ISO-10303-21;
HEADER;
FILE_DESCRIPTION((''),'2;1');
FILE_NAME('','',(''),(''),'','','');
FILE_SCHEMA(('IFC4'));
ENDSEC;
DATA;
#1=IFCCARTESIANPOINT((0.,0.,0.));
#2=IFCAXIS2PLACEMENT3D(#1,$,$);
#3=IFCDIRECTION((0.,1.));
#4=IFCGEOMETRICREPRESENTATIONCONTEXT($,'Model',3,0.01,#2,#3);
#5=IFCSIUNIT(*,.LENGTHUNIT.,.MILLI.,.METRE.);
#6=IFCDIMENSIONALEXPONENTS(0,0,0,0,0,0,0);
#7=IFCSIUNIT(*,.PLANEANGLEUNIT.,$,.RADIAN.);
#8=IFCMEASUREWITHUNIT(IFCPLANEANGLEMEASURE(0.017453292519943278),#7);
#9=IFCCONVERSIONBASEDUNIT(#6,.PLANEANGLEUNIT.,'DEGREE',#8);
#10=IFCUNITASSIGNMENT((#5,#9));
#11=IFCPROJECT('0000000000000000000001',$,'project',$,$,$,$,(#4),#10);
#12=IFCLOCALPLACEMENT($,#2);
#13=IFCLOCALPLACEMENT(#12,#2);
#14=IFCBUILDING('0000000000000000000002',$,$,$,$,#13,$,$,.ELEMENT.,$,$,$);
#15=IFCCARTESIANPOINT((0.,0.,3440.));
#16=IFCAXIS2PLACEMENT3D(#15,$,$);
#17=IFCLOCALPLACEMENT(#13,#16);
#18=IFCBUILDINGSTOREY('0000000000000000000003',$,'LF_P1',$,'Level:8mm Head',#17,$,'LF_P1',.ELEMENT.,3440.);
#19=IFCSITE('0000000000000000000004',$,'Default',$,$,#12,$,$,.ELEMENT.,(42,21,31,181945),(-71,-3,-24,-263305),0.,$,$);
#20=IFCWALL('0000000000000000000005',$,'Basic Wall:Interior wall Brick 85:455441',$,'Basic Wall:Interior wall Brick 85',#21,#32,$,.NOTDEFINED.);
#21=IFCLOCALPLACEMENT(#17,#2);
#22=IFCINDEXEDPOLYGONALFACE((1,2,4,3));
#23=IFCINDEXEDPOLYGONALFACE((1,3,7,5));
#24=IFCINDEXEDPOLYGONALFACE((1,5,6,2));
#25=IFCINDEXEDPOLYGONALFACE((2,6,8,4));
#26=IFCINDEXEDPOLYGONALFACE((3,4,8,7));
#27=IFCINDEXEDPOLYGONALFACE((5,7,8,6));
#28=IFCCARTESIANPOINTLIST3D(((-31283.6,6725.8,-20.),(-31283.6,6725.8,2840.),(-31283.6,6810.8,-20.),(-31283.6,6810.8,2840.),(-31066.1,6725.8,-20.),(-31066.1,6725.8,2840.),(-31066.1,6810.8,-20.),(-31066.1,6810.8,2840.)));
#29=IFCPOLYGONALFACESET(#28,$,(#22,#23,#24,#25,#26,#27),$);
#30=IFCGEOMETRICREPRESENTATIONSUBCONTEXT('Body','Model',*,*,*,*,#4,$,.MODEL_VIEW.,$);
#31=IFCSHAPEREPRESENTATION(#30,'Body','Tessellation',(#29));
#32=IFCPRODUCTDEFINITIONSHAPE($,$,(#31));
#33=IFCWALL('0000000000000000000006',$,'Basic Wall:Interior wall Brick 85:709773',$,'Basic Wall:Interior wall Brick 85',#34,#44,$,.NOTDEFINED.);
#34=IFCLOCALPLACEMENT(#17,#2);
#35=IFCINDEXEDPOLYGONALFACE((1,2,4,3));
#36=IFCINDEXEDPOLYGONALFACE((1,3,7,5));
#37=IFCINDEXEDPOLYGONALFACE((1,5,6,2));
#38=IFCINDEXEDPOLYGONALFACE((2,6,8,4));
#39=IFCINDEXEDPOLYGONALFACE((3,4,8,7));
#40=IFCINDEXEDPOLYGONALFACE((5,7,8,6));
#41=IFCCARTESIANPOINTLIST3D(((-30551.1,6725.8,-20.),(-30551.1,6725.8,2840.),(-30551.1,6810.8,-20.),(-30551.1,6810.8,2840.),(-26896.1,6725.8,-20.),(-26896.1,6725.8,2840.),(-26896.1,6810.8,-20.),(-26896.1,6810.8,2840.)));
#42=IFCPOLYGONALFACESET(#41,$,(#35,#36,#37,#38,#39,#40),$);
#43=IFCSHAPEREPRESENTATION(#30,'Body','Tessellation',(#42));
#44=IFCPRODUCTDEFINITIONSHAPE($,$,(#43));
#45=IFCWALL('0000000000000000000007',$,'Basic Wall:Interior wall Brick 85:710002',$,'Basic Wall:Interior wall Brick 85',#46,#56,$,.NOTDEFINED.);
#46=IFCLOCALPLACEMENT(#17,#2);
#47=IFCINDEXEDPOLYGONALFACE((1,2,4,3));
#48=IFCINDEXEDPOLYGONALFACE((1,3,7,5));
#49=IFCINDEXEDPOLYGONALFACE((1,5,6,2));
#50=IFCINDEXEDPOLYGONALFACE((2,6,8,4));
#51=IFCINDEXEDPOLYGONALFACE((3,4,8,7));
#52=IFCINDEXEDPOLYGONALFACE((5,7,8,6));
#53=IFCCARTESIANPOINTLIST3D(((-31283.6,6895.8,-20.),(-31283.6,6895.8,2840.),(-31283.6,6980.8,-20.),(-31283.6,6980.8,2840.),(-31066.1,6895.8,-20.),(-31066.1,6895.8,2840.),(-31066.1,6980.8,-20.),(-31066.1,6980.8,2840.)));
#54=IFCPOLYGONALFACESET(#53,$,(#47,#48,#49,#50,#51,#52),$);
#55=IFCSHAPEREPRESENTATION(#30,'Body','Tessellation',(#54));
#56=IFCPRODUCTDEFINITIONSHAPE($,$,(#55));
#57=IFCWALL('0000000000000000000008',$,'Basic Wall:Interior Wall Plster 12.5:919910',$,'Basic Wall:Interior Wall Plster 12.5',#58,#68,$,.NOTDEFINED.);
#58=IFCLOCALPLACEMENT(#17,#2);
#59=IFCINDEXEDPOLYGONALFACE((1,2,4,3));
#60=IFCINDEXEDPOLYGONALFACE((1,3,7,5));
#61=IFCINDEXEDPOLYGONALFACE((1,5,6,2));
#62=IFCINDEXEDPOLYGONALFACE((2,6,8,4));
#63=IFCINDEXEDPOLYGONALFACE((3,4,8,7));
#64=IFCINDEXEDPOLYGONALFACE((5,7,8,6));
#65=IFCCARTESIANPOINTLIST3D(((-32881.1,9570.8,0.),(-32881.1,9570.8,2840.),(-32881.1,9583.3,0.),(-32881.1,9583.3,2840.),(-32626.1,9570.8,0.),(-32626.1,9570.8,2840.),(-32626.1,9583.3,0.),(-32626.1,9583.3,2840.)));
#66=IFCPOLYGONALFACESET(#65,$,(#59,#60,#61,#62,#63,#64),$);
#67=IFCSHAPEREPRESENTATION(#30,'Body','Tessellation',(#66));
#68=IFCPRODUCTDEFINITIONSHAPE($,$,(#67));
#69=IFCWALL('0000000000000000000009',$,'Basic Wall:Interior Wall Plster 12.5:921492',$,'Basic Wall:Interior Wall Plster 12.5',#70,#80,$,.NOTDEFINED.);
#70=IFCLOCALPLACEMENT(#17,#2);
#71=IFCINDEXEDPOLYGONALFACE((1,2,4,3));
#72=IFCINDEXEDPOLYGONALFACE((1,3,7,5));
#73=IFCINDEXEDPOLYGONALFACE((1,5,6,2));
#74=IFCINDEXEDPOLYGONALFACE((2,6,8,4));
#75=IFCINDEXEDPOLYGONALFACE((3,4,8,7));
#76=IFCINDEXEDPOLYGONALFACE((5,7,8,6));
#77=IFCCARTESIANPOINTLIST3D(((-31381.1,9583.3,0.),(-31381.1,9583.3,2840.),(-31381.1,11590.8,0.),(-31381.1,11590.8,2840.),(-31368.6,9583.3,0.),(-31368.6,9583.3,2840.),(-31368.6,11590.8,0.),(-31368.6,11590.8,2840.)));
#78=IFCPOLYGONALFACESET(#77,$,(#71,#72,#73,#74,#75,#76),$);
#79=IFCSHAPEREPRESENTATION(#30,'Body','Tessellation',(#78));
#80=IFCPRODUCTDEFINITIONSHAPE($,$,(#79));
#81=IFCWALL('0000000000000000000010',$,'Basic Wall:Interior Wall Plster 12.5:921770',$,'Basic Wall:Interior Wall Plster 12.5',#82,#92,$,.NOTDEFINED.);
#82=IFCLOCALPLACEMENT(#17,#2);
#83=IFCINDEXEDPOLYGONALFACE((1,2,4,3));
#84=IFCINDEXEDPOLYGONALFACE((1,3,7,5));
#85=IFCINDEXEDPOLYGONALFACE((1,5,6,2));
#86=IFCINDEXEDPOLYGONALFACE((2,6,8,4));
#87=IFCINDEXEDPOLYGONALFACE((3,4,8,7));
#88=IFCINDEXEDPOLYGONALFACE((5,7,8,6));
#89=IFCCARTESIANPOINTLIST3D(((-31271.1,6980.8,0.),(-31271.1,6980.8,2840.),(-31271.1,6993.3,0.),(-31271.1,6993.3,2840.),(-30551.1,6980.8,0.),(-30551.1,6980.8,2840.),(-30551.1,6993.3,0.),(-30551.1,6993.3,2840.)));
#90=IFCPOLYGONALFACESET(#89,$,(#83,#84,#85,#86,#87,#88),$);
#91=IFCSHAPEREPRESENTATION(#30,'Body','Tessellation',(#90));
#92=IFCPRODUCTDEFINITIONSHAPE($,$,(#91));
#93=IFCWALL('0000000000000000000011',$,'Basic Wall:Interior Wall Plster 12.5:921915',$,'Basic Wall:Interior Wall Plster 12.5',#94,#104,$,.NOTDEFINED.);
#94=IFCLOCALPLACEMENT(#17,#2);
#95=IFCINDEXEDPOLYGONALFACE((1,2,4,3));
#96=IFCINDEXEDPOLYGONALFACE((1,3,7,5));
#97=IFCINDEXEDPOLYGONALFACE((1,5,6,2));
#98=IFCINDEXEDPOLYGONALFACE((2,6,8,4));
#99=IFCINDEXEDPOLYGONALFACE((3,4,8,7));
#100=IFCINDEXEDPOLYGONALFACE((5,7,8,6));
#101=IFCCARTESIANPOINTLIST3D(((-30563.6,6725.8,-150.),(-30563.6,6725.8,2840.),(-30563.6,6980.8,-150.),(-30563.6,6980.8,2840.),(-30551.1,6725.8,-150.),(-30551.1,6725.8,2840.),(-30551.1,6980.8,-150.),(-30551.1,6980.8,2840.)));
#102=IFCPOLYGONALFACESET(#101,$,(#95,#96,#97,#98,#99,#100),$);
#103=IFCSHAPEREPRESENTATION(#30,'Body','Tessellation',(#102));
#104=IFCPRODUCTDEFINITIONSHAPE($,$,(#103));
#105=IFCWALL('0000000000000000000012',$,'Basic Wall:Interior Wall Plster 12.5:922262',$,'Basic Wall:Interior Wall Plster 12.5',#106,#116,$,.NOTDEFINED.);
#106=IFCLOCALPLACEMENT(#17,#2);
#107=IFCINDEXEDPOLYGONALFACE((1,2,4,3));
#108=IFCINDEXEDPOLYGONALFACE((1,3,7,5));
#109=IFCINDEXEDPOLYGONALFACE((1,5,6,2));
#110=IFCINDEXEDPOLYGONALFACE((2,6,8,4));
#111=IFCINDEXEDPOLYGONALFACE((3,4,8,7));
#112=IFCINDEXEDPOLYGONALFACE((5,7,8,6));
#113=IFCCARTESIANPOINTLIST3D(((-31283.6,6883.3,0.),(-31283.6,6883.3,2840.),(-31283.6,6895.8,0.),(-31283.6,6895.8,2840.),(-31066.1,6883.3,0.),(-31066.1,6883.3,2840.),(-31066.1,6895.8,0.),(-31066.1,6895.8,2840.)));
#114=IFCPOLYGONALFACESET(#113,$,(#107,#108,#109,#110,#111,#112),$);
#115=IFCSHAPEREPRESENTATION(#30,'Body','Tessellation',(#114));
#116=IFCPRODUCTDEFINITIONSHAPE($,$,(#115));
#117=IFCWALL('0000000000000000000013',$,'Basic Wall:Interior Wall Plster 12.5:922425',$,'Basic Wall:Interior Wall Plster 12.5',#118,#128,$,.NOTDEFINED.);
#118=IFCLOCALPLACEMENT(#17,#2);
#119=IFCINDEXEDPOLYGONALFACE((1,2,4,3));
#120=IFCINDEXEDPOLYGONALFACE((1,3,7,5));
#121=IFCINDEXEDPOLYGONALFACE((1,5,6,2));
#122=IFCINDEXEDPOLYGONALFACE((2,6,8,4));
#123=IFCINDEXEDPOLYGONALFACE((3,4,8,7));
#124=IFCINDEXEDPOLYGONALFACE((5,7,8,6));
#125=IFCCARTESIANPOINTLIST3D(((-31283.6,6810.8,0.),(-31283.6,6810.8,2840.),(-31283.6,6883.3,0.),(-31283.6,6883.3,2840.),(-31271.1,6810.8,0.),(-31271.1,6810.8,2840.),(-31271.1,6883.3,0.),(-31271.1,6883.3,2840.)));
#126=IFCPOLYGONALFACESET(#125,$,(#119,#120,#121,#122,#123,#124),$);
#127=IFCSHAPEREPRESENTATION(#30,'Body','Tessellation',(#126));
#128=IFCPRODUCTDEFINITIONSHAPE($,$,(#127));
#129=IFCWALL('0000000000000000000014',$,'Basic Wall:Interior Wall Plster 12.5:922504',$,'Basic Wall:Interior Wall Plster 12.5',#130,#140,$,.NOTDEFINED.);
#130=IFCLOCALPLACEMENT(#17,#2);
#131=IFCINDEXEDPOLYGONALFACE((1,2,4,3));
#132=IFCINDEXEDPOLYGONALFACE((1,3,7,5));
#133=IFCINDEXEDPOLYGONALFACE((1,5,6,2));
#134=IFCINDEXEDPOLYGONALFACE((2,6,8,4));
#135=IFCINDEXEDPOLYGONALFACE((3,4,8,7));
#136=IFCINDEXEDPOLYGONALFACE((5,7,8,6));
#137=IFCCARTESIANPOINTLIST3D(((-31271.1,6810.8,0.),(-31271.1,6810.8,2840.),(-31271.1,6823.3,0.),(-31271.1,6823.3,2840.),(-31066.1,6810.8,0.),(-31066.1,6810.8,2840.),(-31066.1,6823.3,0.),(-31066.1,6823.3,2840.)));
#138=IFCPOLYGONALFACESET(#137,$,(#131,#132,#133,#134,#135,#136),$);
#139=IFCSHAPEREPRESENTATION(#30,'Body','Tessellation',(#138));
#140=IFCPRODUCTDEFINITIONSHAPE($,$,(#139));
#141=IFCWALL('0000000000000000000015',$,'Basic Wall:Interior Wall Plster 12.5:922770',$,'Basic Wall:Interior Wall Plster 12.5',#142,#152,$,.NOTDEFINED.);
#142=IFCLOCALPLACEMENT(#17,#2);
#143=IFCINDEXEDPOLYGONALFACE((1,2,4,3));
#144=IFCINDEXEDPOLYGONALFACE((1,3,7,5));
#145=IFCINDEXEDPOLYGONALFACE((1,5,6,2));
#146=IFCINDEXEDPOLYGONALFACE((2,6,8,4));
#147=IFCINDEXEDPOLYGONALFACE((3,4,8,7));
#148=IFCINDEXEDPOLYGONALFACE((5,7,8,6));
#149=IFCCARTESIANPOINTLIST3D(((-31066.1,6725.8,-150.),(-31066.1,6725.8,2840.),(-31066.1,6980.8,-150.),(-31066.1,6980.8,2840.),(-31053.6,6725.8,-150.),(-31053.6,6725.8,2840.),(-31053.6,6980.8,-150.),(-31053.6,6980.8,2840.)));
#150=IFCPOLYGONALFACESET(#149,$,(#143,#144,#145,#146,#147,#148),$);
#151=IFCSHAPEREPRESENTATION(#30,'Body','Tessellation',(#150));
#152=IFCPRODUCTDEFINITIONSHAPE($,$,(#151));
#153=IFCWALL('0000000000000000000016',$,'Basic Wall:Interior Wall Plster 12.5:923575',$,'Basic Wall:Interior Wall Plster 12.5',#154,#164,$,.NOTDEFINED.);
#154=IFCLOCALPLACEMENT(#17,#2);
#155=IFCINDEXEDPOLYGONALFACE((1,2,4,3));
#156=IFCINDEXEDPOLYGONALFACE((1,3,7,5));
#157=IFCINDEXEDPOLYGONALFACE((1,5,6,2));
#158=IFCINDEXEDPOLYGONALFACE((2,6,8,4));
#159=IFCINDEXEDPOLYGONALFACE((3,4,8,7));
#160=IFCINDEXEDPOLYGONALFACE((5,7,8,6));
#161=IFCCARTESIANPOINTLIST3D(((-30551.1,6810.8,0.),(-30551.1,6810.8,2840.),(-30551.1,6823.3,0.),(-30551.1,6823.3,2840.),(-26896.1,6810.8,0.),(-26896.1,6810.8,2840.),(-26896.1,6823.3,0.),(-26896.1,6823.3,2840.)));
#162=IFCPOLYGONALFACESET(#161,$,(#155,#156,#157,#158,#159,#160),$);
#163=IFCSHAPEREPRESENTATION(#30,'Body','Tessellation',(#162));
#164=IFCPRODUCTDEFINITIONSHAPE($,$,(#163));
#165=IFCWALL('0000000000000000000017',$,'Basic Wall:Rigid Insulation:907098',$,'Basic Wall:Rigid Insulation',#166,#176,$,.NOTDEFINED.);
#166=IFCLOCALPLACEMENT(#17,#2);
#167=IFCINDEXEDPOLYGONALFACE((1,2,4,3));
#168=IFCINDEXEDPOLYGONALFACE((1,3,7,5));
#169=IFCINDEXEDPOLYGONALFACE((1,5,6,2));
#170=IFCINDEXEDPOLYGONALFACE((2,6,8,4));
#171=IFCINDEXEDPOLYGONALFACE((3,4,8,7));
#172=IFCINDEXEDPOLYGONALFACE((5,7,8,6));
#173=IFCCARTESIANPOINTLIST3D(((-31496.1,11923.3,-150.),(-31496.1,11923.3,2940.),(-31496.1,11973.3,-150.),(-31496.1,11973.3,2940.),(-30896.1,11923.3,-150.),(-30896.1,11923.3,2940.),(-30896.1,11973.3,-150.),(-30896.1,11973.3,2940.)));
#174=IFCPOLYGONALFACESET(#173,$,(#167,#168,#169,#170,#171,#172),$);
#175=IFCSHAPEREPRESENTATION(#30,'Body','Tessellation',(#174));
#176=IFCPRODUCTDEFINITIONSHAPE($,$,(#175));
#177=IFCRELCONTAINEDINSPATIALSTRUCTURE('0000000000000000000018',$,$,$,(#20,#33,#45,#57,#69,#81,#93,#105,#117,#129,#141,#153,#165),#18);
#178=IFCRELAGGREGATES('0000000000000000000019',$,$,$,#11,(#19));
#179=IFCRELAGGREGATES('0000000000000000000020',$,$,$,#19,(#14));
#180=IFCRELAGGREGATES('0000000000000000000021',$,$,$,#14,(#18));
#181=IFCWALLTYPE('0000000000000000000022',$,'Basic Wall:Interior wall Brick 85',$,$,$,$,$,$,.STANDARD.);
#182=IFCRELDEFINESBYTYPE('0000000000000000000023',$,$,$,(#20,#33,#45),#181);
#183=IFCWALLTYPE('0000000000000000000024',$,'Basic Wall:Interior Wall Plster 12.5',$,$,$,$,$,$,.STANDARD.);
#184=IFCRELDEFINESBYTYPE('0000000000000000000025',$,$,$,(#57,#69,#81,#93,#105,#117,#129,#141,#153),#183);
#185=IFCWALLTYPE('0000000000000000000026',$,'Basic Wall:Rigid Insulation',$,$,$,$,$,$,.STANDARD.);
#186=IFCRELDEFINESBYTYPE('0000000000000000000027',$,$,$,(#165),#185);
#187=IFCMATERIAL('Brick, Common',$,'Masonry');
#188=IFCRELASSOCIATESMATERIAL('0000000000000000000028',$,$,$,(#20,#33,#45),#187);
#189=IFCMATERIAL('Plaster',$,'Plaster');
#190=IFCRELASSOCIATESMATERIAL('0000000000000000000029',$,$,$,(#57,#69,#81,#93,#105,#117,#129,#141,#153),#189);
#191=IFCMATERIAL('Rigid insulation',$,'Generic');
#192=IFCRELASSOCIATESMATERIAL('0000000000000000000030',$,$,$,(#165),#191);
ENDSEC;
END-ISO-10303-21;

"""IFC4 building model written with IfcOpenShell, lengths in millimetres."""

from ifc_helpers import new_model, entity, si_unit, converted_unit, direction, frame, origin, place, context, subcontext, project, spatial, indexed_curve, outline, extrude, material, type_object, element, save


model = new_model("IFC4")

# Units and contexts
model_context = context("Model", 3, precision=0.01, world=origin(), true_north=direction((0.0, 1.0)))
body_context = subcontext(model_context, "Body", "Model", "MODEL_VIEW")
ifc_project = project(units=[si_unit("LENGTHUNIT", "METRE", prefix="MILLI"), converted_unit("PLANEANGLEUNIT", "DEGREE", entity("IfcPlaneAngleMeasure", 0.017453292519943278), si_unit("PLANEANGLEUNIT", "RADIAN"), dimensions=[0, 0, 0, 0, 0, 0, 0])], contexts=[model_context])

# Site, building, storey
site_placement = place(None, origin())
site = spatial("IfcSite", under=ifc_project, at=site_placement, Name="Default", CompositionType="ELEMENT", RefLatitude=(42, 21, 31, 181945), RefLongitude=(-71, -3, -24, -263305), RefElevation=0.0)
building_placement = place(site_placement, origin())
building = spatial("IfcBuilding", under=site, at=building_placement, CompositionType="ELEMENT")
storey_placement = place(building_placement, frame((0.0, 0.0, 3440.0)))
storey = spatial("IfcBuildingStorey", under=building, at=storey_placement, Name="LF_P1", ObjectType="Level:8mm Head", LongName="LF_P1", CompositionType="ELEMENT", Elevation=3440.0)

# Walls
ifc_material_1 = material(Name="Brick, Common", Category="Masonry")
wall_type_1 = type_object("IfcWallType", Name="Basic Wall:Interior wall Brick 85", PredefinedType="STANDARD")
wall_1_placement = place(storey_placement, frame((-31283.6, 6768.3, -20.0)))
element("IfcWall", 1, at=wall_1_placement, inside=storey, type_object=wall_type_1, material=ifc_material_1, Name="Basic Wall:Interior wall Brick 85:455441", ObjectType="Basic Wall:Interior wall Brick 85", PredefinedType="NOTDEFINED", context=body_context, shape_type="SweptSolid", body=[
    extrude(outline(indexed_curve([(217.5, 42.5), (0.0, 42.5), (0.0, -42.5), (217.5, -42.5), (217.5, 42.5)], self_intersect=False)), origin(), (0.0, 0.0, 1.0), 2860.0),
])
wall_2_placement = place(storey_placement, frame((-30551.1, 6768.3, -20.0)))
element("IfcWall", 2, at=wall_2_placement, inside=storey, type_object=wall_type_1, material=ifc_material_1, Name="Basic Wall:Interior wall Brick 85:709773", ObjectType="Basic Wall:Interior wall Brick 85", PredefinedType="NOTDEFINED", context=body_context, shape_type="SweptSolid", body=[
    extrude(outline(indexed_curve([(3655.0, 42.5), (0.0, 42.5), (0.0, -42.5), (3655.0, -42.5), (3655.0, 42.5)], self_intersect=False)), origin(), (0.0, 0.0, 1.0), 2860.0),
])
wall_3_placement = place(storey_placement, frame((-31283.6, 6938.3, -20.0)))
element("IfcWall", 3, at=wall_3_placement, inside=storey, type_object=wall_type_1, material=ifc_material_1, Name="Basic Wall:Interior wall Brick 85:710002", ObjectType="Basic Wall:Interior wall Brick 85", PredefinedType="NOTDEFINED", context=body_context, shape_type="SweptSolid", body=[
    extrude(outline(indexed_curve([(217.5, 42.5), (0.0, 42.5), (0.0, -42.5), (217.5, -42.5), (217.5, 42.5)], self_intersect=False)), origin(), (0.0, 0.0, 1.0), 2860.0),
])
ifc_material_2 = material(Name="Plaster", Category="Plaster")
wall_type_2 = type_object("IfcWallType", Name="Basic Wall:Interior Wall Plster 12.5", PredefinedType="STANDARD")
wall_4_placement = place(storey_placement, frame((-32881.1, 9577.1, 0.0)))
element("IfcWall", 4, at=wall_4_placement, inside=storey, type_object=wall_type_2, material=ifc_material_2, Name="Basic Wall:Interior Wall Plster 12.5:919910", ObjectType="Basic Wall:Interior Wall Plster 12.5", PredefinedType="NOTDEFINED", context=body_context, shape_type="SweptSolid", body=[
    extrude(outline(indexed_curve([(255.0, 6.2), (0.0, 6.2), (0.0, -6.2), (255.0, -6.2), (255.0, 6.2)], self_intersect=False)), origin(), (0.0, 0.0, 1.0), 2840.0),
])
wall_5_placement = place(storey_placement, frame((-31374.9, 9583.3, 0.0), z_axis=(0.0, 0.0, 1.0), x_axis=(0.0, 1.0, 0.0)))
element("IfcWall", 5, at=wall_5_placement, inside=storey, type_object=wall_type_2, material=ifc_material_2, Name="Basic Wall:Interior Wall Plster 12.5:921492", ObjectType="Basic Wall:Interior Wall Plster 12.5", PredefinedType="NOTDEFINED", context=body_context, shape_type="SweptSolid", body=[
    extrude(outline(indexed_curve([(2007.5, 6.2), (0.0, 6.2), (0.0, -6.2), (2007.5, -6.2), (2007.5, 6.2)], self_intersect=False)), origin(), (0.0, 0.0, 1.0), 2840.0),
])
wall_6_placement = place(storey_placement, frame((-31271.1, 6987.1, 0.0)))
element("IfcWall", 6, at=wall_6_placement, inside=storey, type_object=wall_type_2, material=ifc_material_2, Name="Basic Wall:Interior Wall Plster 12.5:921770", ObjectType="Basic Wall:Interior Wall Plster 12.5", PredefinedType="NOTDEFINED", context=body_context, shape_type="SweptSolid", body=[
    extrude(outline(indexed_curve([(720.0, 6.2), (0.0, 6.2), (0.0, -6.2), (720.0, -6.2), (720.0, 6.2)], self_intersect=False)), origin(), (0.0, 0.0, 1.0), 2840.0),
])
wall_7_placement = place(storey_placement, frame((-30557.4, 6980.8, -150.0), z_axis=(0.0, 0.0, 1.0), x_axis=(0.0, -1.0, 0.0)))
element("IfcWall", 7, at=wall_7_placement, inside=storey, type_object=wall_type_2, material=ifc_material_2, Name="Basic Wall:Interior Wall Plster 12.5:921915", ObjectType="Basic Wall:Interior Wall Plster 12.5", PredefinedType="NOTDEFINED", context=body_context, shape_type="SweptSolid", body=[
    extrude(outline(indexed_curve([(255.0, 6.2), (0.0, 6.2), (0.0, -6.2), (255.0, -6.2), (255.0, 6.2)], self_intersect=False)), origin(), (0.0, 0.0, 1.0), 2990.0),
])
wall_8_placement = place(storey_placement, frame((-31283.6, 6889.6, 0.0)))
element("IfcWall", 8, at=wall_8_placement, inside=storey, type_object=wall_type_2, material=ifc_material_2, Name="Basic Wall:Interior Wall Plster 12.5:922262", ObjectType="Basic Wall:Interior Wall Plster 12.5", PredefinedType="NOTDEFINED", context=body_context, shape_type="SweptSolid", body=[
    extrude(outline(indexed_curve([(217.5, 6.2), (0.0, 6.2), (0.0, -6.2), (217.5, -6.2), (217.5, 6.2)], self_intersect=False)), origin(), (0.0, 0.0, 1.0), 2840.0),
])
wall_9_placement = place(storey_placement, frame((-31277.4, 6883.3, 0.0), z_axis=(0.0, 0.0, 1.0), x_axis=(0.0, -1.0, 0.0)))
element("IfcWall", 9, at=wall_9_placement, inside=storey, type_object=wall_type_2, material=ifc_material_2, Name="Basic Wall:Interior Wall Plster 12.5:922425", ObjectType="Basic Wall:Interior Wall Plster 12.5", PredefinedType="NOTDEFINED", context=body_context, shape_type="SweptSolid", body=[
    extrude(outline(indexed_curve([(72.5, 6.2), (0.0, 6.2), (0.0, -6.2), (72.5, -6.2), (72.5, 6.2)], self_intersect=False)), origin(), (0.0, 0.0, 1.0), 2840.0),
])
wall_10_placement = place(storey_placement, frame((-31271.1, 6817.1, 0.0)))
element("IfcWall", 10, at=wall_10_placement, inside=storey, type_object=wall_type_2, material=ifc_material_2, Name="Basic Wall:Interior Wall Plster 12.5:922504", ObjectType="Basic Wall:Interior Wall Plster 12.5", PredefinedType="NOTDEFINED", context=body_context, shape_type="SweptSolid", body=[
    extrude(outline(indexed_curve([(205.0, 6.2), (0.0, 6.2), (0.0, -6.2), (205.0, -6.2), (205.0, 6.2)], self_intersect=False)), origin(), (0.0, 0.0, 1.0), 2840.0),
])
wall_11_placement = place(storey_placement, frame((-31059.9, 6725.8, -150.0), z_axis=(0.0, 0.0, 1.0), x_axis=(0.0, 1.0, 0.0)))
element("IfcWall", 11, at=wall_11_placement, inside=storey, type_object=wall_type_2, material=ifc_material_2, Name="Basic Wall:Interior Wall Plster 12.5:922770", ObjectType="Basic Wall:Interior Wall Plster 12.5", PredefinedType="NOTDEFINED", context=body_context, shape_type="SweptSolid", body=[
    extrude(outline(indexed_curve([(255.0, 6.2), (0.0, 6.2), (0.0, -6.2), (255.0, -6.2), (255.0, 6.2)], self_intersect=False)), origin(), (0.0, 0.0, 1.0), 2990.0),
])
wall_12_placement = place(storey_placement, frame((-30551.1, 6817.1, 0.0)))
element("IfcWall", 12, at=wall_12_placement, inside=storey, type_object=wall_type_2, material=ifc_material_2, Name="Basic Wall:Interior Wall Plster 12.5:923575", ObjectType="Basic Wall:Interior Wall Plster 12.5", PredefinedType="NOTDEFINED", context=body_context, shape_type="SweptSolid", body=[
    extrude(outline(indexed_curve([(3655.0, 6.2), (0.0, 6.2), (0.0, -6.2), (3655.0, -6.2), (3655.0, 6.2)], self_intersect=False)), origin(), (0.0, 0.0, 1.0), 2840.0),
])
ifc_material_3 = material(Name="Rigid insulation", Category="Generic")
wall_type_3 = type_object("IfcWallType", Name="Basic Wall:Rigid Insulation", PredefinedType="STANDARD")
wall_13_placement = place(storey_placement, frame((-31496.1, 11948.3, -150.0)))
element("IfcWall", 13, at=wall_13_placement, inside=storey, type_object=wall_type_3, material=ifc_material_3, Name="Basic Wall:Rigid Insulation:907098", ObjectType="Basic Wall:Rigid Insulation", PredefinedType="NOTDEFINED", context=body_context, shape_type="SweptSolid", body=[
    extrude(outline(indexed_curve([(600.0, 25.0), (0.0, 25.0), (0.0, -25.0), (600.0, -25.0), (600.0, 25.0)], self_intersect=False)), origin(), (0.0, 0.0, 1.0), 3090.0),
])

save(model, "model.ifc")
